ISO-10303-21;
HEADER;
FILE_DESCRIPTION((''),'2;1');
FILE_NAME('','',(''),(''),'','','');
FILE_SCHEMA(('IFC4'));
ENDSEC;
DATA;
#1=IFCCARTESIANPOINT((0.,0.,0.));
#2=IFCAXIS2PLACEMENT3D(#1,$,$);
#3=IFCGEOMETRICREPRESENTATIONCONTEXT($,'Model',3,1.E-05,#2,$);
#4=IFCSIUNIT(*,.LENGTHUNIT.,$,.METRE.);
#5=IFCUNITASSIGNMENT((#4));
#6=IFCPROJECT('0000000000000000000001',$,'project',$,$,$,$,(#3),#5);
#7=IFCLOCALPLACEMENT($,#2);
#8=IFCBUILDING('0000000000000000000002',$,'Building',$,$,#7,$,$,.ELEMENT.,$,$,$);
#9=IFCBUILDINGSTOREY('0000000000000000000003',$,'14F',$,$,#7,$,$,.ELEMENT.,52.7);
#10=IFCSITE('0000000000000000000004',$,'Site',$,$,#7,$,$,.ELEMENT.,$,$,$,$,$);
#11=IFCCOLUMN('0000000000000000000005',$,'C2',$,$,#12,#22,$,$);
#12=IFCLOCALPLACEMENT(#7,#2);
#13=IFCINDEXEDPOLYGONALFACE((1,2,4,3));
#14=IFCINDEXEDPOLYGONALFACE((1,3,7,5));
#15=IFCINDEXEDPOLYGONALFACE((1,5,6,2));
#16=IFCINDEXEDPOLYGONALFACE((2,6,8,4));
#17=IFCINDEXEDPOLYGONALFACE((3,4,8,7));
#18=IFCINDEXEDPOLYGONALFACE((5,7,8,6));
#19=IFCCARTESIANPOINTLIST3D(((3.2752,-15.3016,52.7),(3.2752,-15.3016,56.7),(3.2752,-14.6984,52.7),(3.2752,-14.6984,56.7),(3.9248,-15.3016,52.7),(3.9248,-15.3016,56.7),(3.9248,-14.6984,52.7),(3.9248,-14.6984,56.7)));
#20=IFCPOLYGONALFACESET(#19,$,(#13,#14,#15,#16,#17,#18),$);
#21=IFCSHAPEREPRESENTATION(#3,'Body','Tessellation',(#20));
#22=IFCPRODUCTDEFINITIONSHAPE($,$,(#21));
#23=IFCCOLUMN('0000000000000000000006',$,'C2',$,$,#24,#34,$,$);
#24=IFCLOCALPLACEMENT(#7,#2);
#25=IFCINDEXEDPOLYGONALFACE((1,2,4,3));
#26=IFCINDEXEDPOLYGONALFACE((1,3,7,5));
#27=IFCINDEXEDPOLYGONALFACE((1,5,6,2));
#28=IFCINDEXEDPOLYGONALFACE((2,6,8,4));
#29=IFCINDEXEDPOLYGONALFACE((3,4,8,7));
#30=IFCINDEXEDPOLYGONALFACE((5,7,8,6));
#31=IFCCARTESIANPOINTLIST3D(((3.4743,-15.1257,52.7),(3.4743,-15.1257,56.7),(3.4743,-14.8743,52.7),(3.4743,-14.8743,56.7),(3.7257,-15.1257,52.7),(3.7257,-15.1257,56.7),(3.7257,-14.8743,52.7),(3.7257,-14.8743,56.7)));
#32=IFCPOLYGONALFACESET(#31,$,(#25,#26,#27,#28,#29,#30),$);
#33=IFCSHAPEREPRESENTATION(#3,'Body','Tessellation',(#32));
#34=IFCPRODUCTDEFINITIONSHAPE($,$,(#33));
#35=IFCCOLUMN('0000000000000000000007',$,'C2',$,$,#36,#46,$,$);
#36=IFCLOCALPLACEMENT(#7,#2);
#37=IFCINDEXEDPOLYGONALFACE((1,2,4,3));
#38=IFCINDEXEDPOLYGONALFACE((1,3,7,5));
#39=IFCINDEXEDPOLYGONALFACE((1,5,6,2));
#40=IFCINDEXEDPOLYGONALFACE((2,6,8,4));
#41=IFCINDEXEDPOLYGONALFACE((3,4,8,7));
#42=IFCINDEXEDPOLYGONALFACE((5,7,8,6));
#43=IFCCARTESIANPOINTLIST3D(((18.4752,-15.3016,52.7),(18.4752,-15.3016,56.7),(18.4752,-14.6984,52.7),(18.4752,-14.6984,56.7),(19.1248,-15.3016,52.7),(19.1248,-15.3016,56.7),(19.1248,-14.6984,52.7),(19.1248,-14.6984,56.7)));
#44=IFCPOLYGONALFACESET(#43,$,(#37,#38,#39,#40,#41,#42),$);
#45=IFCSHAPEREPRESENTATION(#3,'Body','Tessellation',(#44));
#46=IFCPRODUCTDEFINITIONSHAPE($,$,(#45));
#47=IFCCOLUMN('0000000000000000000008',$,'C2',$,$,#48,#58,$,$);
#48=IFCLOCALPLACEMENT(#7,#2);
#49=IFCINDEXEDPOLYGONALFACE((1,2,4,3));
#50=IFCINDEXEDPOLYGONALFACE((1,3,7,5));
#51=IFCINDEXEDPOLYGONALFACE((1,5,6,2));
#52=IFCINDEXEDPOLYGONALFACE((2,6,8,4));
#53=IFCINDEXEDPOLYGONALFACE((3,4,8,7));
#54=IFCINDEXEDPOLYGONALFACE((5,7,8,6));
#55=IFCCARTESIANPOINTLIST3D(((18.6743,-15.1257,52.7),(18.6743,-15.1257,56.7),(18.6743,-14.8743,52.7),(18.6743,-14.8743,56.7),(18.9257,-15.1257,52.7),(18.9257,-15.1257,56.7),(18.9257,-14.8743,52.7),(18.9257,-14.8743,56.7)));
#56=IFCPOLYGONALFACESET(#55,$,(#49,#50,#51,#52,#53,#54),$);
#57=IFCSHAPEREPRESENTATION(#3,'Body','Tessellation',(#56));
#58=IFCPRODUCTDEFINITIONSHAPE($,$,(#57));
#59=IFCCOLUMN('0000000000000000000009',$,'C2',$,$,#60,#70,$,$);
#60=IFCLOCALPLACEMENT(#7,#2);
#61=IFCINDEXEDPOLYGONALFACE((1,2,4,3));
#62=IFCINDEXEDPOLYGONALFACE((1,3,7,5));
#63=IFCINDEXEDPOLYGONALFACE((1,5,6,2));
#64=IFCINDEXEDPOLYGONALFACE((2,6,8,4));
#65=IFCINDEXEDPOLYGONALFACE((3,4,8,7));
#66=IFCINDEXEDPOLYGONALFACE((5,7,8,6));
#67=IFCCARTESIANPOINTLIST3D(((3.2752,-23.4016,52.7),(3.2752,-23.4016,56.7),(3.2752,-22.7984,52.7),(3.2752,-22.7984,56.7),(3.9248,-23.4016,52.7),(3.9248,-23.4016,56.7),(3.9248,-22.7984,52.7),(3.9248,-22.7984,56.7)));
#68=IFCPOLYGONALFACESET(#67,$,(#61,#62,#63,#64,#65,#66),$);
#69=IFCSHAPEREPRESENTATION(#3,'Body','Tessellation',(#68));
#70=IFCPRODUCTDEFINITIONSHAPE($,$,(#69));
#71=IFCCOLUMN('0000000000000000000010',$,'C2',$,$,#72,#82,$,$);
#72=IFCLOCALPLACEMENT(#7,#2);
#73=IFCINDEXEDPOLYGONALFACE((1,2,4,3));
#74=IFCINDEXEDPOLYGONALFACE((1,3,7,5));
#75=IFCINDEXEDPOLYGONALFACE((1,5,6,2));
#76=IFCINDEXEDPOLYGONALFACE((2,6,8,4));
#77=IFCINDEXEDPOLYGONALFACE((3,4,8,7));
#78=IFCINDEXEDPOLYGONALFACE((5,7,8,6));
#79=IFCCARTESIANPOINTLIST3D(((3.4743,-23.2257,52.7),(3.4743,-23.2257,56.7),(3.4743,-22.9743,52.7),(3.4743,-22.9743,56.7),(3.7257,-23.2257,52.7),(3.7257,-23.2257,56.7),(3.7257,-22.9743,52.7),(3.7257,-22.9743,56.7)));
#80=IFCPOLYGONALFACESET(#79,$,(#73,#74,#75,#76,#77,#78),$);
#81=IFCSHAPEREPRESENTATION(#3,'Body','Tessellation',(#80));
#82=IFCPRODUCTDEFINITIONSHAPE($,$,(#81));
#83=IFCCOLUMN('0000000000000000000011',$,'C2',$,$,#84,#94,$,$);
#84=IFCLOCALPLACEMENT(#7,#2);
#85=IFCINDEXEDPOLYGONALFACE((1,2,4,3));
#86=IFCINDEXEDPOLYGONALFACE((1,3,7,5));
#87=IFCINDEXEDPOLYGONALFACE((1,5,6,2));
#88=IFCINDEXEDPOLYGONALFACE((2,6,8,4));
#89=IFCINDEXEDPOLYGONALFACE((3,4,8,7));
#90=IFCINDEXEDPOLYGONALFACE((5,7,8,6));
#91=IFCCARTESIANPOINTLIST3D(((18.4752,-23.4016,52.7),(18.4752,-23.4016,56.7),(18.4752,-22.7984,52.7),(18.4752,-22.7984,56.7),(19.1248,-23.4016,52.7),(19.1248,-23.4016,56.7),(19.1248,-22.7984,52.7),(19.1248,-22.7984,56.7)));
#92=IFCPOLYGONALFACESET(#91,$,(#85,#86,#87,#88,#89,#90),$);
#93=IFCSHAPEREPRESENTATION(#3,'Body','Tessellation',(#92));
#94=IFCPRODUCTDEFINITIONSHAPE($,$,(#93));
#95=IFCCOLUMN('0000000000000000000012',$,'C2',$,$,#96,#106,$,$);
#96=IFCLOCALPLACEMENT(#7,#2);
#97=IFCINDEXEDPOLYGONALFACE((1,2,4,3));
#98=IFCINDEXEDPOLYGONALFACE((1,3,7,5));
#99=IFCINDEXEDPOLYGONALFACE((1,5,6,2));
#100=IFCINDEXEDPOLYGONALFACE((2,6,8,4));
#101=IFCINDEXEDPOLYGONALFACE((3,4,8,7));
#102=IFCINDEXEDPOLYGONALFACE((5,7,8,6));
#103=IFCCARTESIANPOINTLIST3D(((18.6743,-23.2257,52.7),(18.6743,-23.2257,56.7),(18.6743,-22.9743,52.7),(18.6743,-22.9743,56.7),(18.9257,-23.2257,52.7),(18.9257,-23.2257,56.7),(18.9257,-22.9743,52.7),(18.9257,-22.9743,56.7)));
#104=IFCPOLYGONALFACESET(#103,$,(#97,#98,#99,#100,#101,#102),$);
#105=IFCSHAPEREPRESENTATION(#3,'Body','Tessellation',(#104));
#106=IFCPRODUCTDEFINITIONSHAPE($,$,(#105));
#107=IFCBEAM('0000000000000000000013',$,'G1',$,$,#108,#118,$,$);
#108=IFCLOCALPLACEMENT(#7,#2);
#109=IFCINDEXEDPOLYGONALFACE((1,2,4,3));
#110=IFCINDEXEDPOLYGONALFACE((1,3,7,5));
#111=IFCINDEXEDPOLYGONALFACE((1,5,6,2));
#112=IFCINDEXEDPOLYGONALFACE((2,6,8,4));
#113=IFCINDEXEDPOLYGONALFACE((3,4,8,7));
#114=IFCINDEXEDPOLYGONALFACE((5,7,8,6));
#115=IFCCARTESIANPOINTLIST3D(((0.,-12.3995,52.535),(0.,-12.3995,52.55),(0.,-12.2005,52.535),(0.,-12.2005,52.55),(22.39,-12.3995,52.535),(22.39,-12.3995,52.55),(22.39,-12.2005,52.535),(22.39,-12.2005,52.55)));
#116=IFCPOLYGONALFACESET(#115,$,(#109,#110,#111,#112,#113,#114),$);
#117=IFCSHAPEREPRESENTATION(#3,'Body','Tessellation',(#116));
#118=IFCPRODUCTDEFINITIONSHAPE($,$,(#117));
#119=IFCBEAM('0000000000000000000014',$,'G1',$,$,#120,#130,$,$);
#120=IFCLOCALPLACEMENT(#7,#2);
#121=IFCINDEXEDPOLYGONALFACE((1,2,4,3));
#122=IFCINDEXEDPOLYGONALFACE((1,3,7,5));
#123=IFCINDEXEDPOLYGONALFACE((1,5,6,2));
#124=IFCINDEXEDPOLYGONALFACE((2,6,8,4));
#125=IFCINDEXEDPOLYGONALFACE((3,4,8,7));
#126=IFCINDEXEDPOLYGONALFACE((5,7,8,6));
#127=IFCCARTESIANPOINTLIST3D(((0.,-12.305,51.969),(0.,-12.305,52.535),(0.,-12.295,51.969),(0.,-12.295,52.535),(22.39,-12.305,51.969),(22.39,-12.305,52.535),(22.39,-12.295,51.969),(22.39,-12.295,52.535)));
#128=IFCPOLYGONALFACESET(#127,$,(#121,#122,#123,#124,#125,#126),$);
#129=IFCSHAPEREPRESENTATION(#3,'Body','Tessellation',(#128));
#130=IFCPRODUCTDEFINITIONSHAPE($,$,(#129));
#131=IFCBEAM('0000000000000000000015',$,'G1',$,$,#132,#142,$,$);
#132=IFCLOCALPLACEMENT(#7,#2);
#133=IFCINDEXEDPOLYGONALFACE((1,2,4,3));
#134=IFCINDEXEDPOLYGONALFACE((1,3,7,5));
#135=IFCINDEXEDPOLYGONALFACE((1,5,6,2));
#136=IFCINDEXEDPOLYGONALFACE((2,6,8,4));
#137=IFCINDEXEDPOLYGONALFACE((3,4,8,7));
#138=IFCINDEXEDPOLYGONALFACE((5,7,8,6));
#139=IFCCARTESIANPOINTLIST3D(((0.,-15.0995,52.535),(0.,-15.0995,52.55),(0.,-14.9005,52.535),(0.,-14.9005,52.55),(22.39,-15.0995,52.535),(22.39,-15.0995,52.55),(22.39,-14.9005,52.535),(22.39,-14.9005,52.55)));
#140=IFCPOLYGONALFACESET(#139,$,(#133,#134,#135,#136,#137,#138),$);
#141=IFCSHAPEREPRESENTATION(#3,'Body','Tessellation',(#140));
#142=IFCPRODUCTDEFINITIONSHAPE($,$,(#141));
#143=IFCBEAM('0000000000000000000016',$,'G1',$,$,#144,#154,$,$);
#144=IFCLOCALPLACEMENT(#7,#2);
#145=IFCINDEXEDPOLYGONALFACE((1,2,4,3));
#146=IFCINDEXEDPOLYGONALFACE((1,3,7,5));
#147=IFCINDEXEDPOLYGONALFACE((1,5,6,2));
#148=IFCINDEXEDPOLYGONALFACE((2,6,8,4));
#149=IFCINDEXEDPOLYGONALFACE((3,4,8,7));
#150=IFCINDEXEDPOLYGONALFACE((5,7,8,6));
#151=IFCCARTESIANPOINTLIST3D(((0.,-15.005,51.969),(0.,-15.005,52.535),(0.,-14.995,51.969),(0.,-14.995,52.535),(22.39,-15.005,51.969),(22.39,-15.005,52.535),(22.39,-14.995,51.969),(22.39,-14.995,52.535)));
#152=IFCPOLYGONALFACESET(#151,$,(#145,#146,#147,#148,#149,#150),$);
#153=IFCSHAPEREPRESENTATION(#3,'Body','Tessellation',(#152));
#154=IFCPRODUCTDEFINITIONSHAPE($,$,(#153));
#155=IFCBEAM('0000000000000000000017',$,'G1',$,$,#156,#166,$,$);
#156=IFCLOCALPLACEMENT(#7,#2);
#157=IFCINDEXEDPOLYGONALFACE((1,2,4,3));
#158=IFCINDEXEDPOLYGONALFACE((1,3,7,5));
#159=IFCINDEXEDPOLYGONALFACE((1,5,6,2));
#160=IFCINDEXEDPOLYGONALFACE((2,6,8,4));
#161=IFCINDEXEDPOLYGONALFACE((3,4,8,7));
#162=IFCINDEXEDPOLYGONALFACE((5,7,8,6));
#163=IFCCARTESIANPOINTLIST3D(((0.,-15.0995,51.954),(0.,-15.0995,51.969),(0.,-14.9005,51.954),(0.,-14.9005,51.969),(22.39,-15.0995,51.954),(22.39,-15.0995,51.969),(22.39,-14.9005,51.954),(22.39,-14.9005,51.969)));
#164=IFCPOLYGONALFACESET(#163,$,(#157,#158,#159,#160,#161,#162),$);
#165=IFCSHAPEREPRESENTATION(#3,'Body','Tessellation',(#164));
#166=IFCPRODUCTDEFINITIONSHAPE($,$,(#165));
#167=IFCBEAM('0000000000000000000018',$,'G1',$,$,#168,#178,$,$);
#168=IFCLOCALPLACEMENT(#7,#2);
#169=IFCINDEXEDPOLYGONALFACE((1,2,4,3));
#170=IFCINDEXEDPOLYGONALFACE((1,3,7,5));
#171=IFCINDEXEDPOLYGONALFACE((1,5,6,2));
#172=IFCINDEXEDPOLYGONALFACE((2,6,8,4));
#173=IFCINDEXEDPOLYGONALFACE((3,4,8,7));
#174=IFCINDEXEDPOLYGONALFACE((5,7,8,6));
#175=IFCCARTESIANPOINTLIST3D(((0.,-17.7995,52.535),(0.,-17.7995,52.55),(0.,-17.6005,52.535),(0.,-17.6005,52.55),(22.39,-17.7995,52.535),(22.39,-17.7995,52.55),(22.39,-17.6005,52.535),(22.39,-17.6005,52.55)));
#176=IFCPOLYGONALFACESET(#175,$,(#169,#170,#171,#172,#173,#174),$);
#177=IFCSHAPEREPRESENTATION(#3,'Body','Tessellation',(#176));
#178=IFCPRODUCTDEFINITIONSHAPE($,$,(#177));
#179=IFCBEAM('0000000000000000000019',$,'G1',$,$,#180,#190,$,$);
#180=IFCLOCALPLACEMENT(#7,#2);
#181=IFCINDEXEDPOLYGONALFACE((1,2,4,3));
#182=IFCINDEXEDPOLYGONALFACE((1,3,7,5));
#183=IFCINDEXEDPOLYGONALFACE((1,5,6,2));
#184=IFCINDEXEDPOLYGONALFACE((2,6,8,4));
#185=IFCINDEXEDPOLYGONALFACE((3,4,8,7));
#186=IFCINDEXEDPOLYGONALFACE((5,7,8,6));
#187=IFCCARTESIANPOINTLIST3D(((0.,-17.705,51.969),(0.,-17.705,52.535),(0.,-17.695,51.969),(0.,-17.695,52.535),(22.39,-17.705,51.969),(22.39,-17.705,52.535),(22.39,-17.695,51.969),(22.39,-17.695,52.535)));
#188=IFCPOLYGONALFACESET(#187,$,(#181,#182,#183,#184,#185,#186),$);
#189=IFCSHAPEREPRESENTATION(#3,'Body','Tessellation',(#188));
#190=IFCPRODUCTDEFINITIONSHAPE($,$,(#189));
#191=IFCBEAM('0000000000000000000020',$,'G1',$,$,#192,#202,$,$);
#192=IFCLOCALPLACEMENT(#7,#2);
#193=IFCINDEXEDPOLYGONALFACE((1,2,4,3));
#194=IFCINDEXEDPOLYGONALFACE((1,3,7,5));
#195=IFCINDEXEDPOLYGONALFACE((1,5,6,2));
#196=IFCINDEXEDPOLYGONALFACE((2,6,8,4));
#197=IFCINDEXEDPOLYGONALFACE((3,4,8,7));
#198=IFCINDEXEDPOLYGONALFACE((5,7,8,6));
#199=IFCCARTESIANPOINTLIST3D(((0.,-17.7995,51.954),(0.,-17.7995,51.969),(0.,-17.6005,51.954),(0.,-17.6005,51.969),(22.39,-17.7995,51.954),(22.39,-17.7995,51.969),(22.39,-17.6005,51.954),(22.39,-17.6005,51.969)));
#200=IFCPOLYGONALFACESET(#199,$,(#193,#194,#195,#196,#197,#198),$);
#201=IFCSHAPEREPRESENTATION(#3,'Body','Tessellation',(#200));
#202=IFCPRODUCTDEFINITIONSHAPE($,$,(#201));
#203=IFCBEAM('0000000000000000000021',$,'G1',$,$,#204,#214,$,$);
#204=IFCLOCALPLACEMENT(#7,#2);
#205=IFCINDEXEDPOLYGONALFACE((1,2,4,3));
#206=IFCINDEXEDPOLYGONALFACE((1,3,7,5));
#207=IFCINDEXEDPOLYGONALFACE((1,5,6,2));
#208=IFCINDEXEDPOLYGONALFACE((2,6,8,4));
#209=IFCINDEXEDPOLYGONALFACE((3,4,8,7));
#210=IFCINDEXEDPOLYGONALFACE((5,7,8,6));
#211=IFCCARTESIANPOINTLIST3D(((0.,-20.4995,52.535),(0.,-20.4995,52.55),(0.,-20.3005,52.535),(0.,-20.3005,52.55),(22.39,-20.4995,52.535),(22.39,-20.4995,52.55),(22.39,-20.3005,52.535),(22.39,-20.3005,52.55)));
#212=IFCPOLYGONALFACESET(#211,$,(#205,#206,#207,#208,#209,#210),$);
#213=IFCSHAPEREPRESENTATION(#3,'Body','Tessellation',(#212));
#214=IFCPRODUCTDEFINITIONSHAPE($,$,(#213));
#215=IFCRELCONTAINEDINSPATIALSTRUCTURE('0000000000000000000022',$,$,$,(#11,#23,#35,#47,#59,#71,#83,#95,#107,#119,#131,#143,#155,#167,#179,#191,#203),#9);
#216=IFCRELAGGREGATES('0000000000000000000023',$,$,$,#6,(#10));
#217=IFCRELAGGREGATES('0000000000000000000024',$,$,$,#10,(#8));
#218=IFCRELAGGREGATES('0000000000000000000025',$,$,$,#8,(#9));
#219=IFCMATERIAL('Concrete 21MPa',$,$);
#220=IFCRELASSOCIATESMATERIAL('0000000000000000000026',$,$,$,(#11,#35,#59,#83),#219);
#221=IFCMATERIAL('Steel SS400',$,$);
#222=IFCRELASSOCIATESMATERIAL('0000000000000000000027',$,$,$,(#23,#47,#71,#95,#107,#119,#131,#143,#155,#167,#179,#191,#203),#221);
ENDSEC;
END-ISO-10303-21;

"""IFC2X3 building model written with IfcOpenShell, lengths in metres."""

from ifc_helpers import new_model, si_unit, frame, origin, origin_2d, place, context, project, spatial, rectangle, extrude, material, element, save


model = new_model("IFC2X3")

# Units and contexts
model_context = context("Model", 3, precision=1e-05, world=origin())
ifc_project = project(units=[si_unit("LENGTHUNIT", "METRE")], contexts=[model_context])

# Site, building, storey
placement = place(None, origin())
site = spatial("IfcSite", under=ifc_project, at=placement, Name="Site", CompositionType="ELEMENT")
building = spatial("IfcBuilding", under=site, at=placement, Name="Building", CompositionType="ELEMENT")
storey = spatial("IfcBuildingStorey", under=building, at=placement, Name="14F", CompositionType="ELEMENT", Elevation=52.7)

# Columns
ifc_material_1 = material(Name="Concrete 21MPa")
column_1_placement = place(None, frame((3.6, -15.0, 52.7)))
element("IfcColumn", 1, at=column_1_placement, inside=storey, material=ifc_material_1, Name="C2", context=model_context, shape_type="SweptSolid", body=[
    extrude(rectangle(XDim=0.6496, YDim=0.6032, at=origin_2d()), origin(), (0.0, 0.0, 1.0), 4.0),
])
ifc_material_2 = material(Name="Steel SS400")
column_2_placement = place(None, frame((3.6, -15.0, 52.7)))
element("IfcColumn", 2, at=column_2_placement, inside=storey, material=ifc_material_2, Name="C2", context=model_context, shape_type="SweptSolid", body=[
    extrude(rectangle(XDim=0.2513, YDim=0.2513, at=origin_2d()), origin(), (0.0, 0.0, 1.0), 4.0),
])
column_3_placement = place(None, frame((18.8, -15.0, 52.7)))
element("IfcColumn", 3, at=column_3_placement, inside=storey, material=ifc_material_1, Name="C2", context=model_context, shape_type="SweptSolid", body=[
    extrude(rectangle(XDim=0.6496, YDim=0.6032, at=origin_2d()), origin(), (0.0, 0.0, 1.0), 4.0),
])
column_4_placement = place(None, frame((18.8, -15.0, 52.7)))
element("IfcColumn", 4, at=column_4_placement, inside=storey, material=ifc_material_2, Name="C2", context=model_context, shape_type="SweptSolid", body=[
    extrude(rectangle(XDim=0.2513, YDim=0.2513, at=origin_2d()), origin(), (0.0, 0.0, 1.0), 4.0),
])
column_5_placement = place(None, frame((3.6, -23.1, 52.7)))
element("IfcColumn", 5, at=column_5_placement, inside=storey, material=ifc_material_1, Name="C2", context=model_context, shape_type="SweptSolid", body=[
    extrude(rectangle(XDim=0.6496, YDim=0.6032, at=origin_2d()), origin(), (0.0, 0.0, 1.0), 4.0),
])
column_6_placement = place(None, frame((3.6, -23.1, 52.7)))
element("IfcColumn", 6, at=column_6_placement, inside=storey, material=ifc_material_2, Name="C2", context=model_context, shape_type="SweptSolid", body=[
    extrude(rectangle(XDim=0.2513, YDim=0.2513, at=origin_2d()), origin(), (0.0, 0.0, 1.0), 4.0),
])
column_7_placement = place(None, frame((18.8, -23.1, 52.7)))
element("IfcColumn", 7, at=column_7_placement, inside=storey, material=ifc_material_1, Name="C2", context=model_context, shape_type="SweptSolid", body=[
    extrude(rectangle(XDim=0.6496, YDim=0.6032, at=origin_2d()), origin(), (0.0, 0.0, 1.0), 4.0),
])
column_8_placement = place(None, frame((18.8, -23.1, 52.7)))
element("IfcColumn", 8, at=column_8_placement, inside=storey, material=ifc_material_2, Name="C2", context=model_context, shape_type="SweptSolid", body=[
    extrude(rectangle(XDim=0.2513, YDim=0.2513, at=origin_2d()), origin(), (0.0, 0.0, 1.0), 4.0),
])

# Beams
beam_1_placement = place(None, frame((11.195, -12.3, 52.535)))
element("IfcBeam", 9, at=beam_1_placement, inside=storey, material=ifc_material_2, Name="G1", context=model_context, shape_type="SweptSolid", body=[
    extrude(rectangle(XDim=22.39, YDim=0.199, at=origin_2d()), origin(), (0.0, 0.0, 1.0), 0.015),
])
beam_2_placement = place(None, frame((11.195, -12.3, 51.969)))
element("IfcBeam", 10, at=beam_2_placement, inside=storey, material=ifc_material_2, Name="G1", context=model_context, shape_type="SweptSolid", body=[
    extrude(rectangle(XDim=22.39, YDim=0.01, at=origin_2d()), origin(), (0.0, 0.0, 1.0), 0.566),
])
beam_3_placement = place(None, frame((11.195, -15.0, 52.535)))
element("IfcBeam", 11, at=beam_3_placement, inside=storey, material=ifc_material_2, Name="G1", context=model_context, shape_type="SweptSolid", body=[
    extrude(rectangle(XDim=22.39, YDim=0.199, at=origin_2d()), origin(), (0.0, 0.0, 1.0), 0.015),
])
beam_4_placement = place(None, frame((11.195, -15.0, 51.969)))
element("IfcBeam", 12, at=beam_4_placement, inside=storey, material=ifc_material_2, Name="G1", context=model_context, shape_type="SweptSolid", body=[
    extrude(rectangle(XDim=22.39, YDim=0.01, at=origin_2d()), origin(), (0.0, 0.0, 1.0), 0.566),
])
for number, where, name in (
    (13, (11.195, -15.0, 51.954), "G1"),
    (14, (11.195, -17.7, 52.535), "G1"),
):
    element("IfcBeam", number, at=place(None, frame(where)), inside=storey, material=ifc_material_2, Name=name, context=model_context, shape_type="SweptSolid", body=[
        extrude(rectangle(XDim=22.39, YDim=0.199, at=origin_2d()), origin(), (0.0, 0.0, 1.0), 0.015),
    ])
beam_5_placement = place(None, frame((11.195, -17.7, 51.969)))
element("IfcBeam", 15, at=beam_5_placement, inside=storey, material=ifc_material_2, Name="G1", context=model_context, shape_type="SweptSolid", body=[
    extrude(rectangle(XDim=22.39, YDim=0.01, at=origin_2d()), origin(), (0.0, 0.0, 1.0), 0.566),
])
for number, where, name in (
    (16, (11.195, -17.7, 51.954), "G1"),
    (17, (11.195, -20.4, 52.535), "G1"),
):
    element("IfcBeam", number, at=place(None, frame(where)), inside=storey, material=ifc_material_2, Name=name, context=model_context, shape_type="SweptSolid", body=[
        extrude(rectangle(XDim=22.39, YDim=0.199, at=origin_2d()), origin(), (0.0, 0.0, 1.0), 0.015),
    ])

save(model, "model.ifc")
